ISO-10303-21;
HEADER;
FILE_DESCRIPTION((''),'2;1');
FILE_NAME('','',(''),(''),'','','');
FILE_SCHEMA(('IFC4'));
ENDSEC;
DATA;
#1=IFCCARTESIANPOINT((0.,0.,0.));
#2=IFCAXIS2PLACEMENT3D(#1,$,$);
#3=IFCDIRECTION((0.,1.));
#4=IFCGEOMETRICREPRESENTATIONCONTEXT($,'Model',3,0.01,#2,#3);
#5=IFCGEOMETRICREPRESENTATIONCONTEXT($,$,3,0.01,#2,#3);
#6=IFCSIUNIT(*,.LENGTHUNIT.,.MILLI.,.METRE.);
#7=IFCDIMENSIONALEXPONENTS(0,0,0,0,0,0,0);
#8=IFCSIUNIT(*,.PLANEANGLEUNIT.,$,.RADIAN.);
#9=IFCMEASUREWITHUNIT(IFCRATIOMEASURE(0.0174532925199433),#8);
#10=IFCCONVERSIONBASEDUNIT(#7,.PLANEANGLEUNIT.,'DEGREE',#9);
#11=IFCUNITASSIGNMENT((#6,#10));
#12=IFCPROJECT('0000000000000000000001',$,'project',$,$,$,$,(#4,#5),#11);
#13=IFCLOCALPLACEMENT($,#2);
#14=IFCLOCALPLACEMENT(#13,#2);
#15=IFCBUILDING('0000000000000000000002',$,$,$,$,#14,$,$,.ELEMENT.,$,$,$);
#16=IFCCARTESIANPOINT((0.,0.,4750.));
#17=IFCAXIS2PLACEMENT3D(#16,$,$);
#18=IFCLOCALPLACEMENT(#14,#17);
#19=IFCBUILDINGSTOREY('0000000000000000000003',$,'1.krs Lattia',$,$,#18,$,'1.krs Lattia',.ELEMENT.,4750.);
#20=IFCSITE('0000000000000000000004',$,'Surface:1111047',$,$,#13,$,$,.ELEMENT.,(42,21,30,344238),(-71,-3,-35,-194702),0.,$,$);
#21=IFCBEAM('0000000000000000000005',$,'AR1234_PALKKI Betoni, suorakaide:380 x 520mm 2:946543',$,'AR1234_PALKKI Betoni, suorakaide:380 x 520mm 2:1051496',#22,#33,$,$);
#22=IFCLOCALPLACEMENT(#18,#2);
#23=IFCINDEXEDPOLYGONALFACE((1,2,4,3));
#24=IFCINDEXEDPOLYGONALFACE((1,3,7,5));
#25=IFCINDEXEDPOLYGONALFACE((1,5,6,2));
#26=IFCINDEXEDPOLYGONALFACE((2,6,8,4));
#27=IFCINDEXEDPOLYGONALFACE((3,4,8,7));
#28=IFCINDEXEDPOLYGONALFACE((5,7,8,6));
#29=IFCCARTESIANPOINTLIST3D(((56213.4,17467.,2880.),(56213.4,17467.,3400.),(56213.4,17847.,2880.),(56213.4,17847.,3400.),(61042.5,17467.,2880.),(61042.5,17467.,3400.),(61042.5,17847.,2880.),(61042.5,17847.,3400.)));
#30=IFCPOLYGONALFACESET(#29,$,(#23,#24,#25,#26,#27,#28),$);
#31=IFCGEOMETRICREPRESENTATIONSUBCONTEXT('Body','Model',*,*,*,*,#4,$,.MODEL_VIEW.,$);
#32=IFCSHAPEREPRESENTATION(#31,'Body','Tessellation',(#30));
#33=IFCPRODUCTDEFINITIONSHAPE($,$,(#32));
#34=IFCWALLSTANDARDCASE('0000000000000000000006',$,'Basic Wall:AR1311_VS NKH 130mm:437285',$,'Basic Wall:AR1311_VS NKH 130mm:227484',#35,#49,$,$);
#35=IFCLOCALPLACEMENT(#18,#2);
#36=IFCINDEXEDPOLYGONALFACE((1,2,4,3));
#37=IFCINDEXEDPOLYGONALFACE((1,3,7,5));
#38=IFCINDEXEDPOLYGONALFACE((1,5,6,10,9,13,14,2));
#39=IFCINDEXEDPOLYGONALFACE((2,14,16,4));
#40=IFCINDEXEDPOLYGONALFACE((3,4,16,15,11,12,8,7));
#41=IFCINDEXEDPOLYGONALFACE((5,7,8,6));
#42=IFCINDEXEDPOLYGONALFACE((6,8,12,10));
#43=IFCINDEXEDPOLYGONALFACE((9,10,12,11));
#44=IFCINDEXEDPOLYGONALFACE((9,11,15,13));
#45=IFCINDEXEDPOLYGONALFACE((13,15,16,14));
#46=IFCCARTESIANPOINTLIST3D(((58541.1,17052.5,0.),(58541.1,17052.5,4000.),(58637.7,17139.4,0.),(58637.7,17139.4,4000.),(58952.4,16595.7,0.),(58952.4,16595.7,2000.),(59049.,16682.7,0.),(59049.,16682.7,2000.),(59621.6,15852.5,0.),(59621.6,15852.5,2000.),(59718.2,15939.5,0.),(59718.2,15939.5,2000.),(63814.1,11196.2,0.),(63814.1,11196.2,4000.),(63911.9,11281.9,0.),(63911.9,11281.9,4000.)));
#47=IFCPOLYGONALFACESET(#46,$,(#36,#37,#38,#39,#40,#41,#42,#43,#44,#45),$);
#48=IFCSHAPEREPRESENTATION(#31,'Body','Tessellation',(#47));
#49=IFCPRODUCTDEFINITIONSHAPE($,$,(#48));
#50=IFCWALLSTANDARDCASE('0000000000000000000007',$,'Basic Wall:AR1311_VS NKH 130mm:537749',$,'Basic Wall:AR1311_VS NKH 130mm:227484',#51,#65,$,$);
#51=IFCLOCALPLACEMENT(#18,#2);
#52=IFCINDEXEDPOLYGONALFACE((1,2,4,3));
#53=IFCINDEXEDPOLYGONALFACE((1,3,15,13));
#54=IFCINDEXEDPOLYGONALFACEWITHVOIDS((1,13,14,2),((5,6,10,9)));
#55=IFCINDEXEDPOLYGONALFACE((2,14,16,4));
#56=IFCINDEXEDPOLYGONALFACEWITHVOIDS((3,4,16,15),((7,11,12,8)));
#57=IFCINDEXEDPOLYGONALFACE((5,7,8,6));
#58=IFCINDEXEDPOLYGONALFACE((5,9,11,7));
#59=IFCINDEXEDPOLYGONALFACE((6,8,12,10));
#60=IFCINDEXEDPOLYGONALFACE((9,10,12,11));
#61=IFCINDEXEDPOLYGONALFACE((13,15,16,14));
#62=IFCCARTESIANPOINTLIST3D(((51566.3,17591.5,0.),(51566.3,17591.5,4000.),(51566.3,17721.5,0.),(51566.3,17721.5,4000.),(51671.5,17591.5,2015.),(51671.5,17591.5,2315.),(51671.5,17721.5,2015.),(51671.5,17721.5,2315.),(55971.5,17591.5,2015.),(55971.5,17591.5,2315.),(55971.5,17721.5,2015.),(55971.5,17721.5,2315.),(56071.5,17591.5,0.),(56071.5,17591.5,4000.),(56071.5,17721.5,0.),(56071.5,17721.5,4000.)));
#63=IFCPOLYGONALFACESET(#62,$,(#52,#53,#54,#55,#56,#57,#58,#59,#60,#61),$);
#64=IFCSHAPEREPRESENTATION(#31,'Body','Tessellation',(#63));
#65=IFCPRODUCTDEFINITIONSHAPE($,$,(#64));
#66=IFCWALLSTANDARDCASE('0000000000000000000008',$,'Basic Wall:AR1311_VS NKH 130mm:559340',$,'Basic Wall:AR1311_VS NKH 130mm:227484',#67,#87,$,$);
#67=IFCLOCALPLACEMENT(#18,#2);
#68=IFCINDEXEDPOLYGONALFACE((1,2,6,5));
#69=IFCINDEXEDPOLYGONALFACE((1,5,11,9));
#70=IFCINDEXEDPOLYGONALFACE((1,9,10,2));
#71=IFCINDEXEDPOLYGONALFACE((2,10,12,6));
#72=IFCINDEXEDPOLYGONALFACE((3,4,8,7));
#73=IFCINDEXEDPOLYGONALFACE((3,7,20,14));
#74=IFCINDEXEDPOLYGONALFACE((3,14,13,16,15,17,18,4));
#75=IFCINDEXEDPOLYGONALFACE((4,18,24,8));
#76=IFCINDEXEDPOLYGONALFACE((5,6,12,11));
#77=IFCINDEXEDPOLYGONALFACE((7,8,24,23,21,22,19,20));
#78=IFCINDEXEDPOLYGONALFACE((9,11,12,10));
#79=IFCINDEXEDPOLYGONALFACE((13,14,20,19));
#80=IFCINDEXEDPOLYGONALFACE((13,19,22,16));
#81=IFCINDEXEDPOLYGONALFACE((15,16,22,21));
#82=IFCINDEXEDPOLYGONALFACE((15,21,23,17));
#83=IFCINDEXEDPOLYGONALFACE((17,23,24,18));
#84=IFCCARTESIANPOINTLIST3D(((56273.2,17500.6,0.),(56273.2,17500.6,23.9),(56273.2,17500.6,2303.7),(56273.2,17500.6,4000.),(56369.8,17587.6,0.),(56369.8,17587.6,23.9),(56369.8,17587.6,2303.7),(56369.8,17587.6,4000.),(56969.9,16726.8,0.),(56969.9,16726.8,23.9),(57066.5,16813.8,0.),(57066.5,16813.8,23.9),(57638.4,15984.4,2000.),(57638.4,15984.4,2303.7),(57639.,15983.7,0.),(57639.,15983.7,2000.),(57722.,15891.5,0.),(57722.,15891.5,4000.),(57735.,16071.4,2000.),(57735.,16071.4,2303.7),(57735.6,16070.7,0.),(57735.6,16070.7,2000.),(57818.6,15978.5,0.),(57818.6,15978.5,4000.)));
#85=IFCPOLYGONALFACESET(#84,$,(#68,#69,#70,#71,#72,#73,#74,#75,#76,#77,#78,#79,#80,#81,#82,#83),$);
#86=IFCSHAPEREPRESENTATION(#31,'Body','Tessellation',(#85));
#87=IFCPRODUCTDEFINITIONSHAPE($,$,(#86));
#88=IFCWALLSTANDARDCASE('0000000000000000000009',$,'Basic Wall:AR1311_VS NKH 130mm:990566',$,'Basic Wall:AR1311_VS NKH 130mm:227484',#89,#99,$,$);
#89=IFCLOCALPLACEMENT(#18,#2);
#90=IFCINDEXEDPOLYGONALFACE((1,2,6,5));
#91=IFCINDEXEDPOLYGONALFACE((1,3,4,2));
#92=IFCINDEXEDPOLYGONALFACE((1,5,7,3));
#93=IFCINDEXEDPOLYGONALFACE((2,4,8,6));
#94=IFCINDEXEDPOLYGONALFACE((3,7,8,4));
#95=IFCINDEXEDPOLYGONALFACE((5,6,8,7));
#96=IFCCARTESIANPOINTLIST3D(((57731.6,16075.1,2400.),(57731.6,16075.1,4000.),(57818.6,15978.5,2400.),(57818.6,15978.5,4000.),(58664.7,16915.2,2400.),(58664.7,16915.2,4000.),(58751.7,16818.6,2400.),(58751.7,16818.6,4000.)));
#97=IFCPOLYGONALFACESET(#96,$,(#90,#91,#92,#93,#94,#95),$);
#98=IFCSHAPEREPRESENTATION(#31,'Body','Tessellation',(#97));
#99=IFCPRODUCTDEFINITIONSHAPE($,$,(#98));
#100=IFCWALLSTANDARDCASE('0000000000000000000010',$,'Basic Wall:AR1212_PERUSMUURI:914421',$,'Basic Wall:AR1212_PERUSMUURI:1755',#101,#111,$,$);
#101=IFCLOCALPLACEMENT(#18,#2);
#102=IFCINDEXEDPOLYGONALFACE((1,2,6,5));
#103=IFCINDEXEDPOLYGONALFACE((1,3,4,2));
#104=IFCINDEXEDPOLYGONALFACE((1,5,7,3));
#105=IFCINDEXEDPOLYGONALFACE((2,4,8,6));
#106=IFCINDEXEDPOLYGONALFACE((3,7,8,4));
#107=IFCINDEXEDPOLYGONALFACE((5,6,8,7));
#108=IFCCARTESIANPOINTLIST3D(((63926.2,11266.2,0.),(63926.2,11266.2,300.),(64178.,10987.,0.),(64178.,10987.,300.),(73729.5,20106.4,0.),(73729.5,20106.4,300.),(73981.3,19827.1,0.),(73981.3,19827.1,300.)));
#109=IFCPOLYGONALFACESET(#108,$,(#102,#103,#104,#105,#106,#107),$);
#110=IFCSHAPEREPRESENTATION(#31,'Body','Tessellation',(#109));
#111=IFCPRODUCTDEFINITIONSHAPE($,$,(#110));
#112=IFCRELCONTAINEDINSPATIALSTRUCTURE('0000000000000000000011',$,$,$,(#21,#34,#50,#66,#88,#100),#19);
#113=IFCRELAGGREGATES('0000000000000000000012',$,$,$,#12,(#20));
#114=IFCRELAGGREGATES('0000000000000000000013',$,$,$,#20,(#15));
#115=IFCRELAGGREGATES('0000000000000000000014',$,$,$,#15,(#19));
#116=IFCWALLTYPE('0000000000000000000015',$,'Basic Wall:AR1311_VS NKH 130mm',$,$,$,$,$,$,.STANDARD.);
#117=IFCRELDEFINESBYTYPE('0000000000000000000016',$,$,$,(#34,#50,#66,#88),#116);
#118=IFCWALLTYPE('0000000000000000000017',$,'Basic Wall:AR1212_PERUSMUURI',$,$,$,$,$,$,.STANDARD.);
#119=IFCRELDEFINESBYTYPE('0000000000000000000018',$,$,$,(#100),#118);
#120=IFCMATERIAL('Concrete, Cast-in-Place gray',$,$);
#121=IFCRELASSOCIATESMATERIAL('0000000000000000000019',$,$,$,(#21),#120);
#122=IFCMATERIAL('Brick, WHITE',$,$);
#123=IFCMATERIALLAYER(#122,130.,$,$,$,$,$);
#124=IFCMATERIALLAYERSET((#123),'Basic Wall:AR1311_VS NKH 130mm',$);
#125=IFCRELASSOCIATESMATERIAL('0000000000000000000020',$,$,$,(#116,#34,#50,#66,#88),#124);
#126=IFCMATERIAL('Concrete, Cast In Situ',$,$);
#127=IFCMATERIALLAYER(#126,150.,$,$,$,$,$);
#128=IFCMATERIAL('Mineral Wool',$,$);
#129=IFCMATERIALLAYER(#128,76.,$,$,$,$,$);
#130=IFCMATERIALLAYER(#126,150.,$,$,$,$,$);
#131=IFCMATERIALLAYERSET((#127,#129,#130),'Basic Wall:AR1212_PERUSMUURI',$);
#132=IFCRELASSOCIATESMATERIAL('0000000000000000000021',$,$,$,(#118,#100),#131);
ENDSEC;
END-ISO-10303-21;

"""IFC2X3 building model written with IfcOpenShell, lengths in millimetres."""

from ifc_helpers import new_model, entity, si_unit, converted_unit, direction, frame, frame_2d, origin, place, context, subcontext, project, spatial, polyline, rectangle, outline, extrude, material, layer, layer_set, layer_usage, type_object, element, save


model = new_model("IFC2X3")

# Units and contexts
model_context = context("Model", 3, precision=0.01, world=origin(), true_north=direction((0.0, 1.0)))
context_of_model = context(None, 3, precision=0.01, world=origin(), true_north=direction((0.0, 1.0)))
body_context = subcontext(model_context, "Body", "Model", "MODEL_VIEW")
ifc_project = project(units=[si_unit("LENGTHUNIT", "METRE", prefix="MILLI"), converted_unit("PLANEANGLEUNIT", "DEGREE", entity("IfcRatioMeasure", 0.0174532925199433), si_unit("PLANEANGLEUNIT", "RADIAN"), dimensions=[0, 0, 0, 0, 0, 0, 0])], contexts=[model_context, context_of_model])

# Site, building, storey
site_placement = place(None, origin())
site = spatial("IfcSite", under=ifc_project, at=site_placement, Name="Surface:1111047", CompositionType="ELEMENT", RefLatitude=(42, 21, 30, 344238), RefLongitude=(-71, -3, -35, -194702), RefElevation=0.0)
building_placement = place(site_placement, origin())
building = spatial("IfcBuilding", under=site, at=building_placement, CompositionType="ELEMENT")
storey_placement = place(building_placement, frame((0.0, 0.0, 4750.0)))
storey = spatial("IfcBuildingStorey", under=building, at=storey_placement, Name="1.krs Lattia", LongName="1.krs Lattia", CompositionType="ELEMENT", Elevation=4750.0)

# Beam
ifc_material_1 = material(Name="Concrete, Cast-in-Place gray")
beam_1_placement = place(storey_placement, frame((61042.5, 17657.0, 0.0), z_axis=(0.0, 0.0, 1.0), x_axis=(-1.0, 0.0, 0.0)))
element("IfcBeam", 1, at=beam_1_placement, inside=storey, material=ifc_material_1, Name="AR1234_PALKKI Betoni, suorakaide:380 x 520mm 2:946543", ObjectType="AR1234_PALKKI Betoni, suorakaide:380 x 520mm 2:1051496", context=body_context, shape_type="SweptSolid", body=[
    extrude(rectangle(XDim=520.0, YDim=380.0, at=frame_2d((0.0, 0.0), x_axis=(1.0, 0.0))), frame((0.0, 0.0, 3140.0), z_axis=(1.0, 0.0, 0.0), x_axis=(0.0, 0.0, -1.0)), (0.0, 0.0, 1.0), 4829.1),
])

# Walls, openings
ifc_material_2 = material(Name="Brick, WHITE")
ifc_layer_1 = layer(ifc_material_2, 130.0)
ifc_layer_set_1 = layer_set([ifc_layer_1], Name="Basic Wall:AR1311_VS NKH 130mm")
ifc_layer_usage_1 = layer_usage(ifc_layer_set_1, "AXIS2", "NEGATIVE", 65.0)
wall_type_1 = type_object("IfcWallType", Name="Basic Wall:AR1311_VS NKH 130mm", PredefinedType="STANDARD", material=ifc_layer_set_1)
wall_1_placement = place(storey_placement, frame((58589.4, 17096.0, 0.0), z_axis=(0.0, 0.0, 1.0), x_axis=(0.669131, -0.743145, 0.0)))
wall_1 = element("IfcWallStandardCase", 2, at=wall_1_placement, inside=storey, type_object=wall_type_1, material=ifc_layer_usage_1, Name="Basic Wall:AR1311_VS NKH 130mm:437285", ObjectType="Basic Wall:AR1311_VS NKH 130mm:227484", context=body_context, shape_type="SweptSolid", body=[
    extrude(outline(polyline([(0.0, -65.0), (7880.4, -65.0), (7882.2, 65.0), (0.0, 65.0), (0.0, -65.0)])), origin(), (0.0, 0.0, 1.0), 4000.0),
])
opening_1_placement = place(wall_1_placement, frame((614.7, -65.0, 0.0)))
element("IfcOpeningElement", 3, at=opening_1_placement, cuts=wall_1, ObjectType="Opening", context=body_context, shape_type="SweptSolid", body=[
    extrude(rectangle(XDim=2000.0, YDim=1000.0, at=frame_2d((1000.0, 500.0), x_axis=(1.0, 0.0))), frame((0.0, 0.0, 0.0), z_axis=(0.0, 1.0, 0.0), x_axis=(0.0, 0.0, 1.0)), (0.0, 0.0, 1.0), 130.0),
])
ifc_layer_usage_2 = layer_usage(ifc_layer_set_1, "AXIS2", "NEGATIVE", 65.0)
wall_2_placement = place(storey_placement, frame((51566.3, 17656.5, 0.0)))
wall_2 = element("IfcWallStandardCase", 4, at=wall_2_placement, inside=storey, type_object=wall_type_1, material=ifc_layer_usage_2, Name="Basic Wall:AR1311_VS NKH 130mm:537749", ObjectType="Basic Wall:AR1311_VS NKH 130mm:227484", context=body_context, shape_type="SweptSolid", body=[
    extrude(rectangle(XDim=4505.2, YDim=130.0, at=frame_2d((2252.6, 0.0), x_axis=(-1.0, 0.0))), origin(), (0.0, 0.0, 1.0), 4000.0),
])
opening_2_placement = place(wall_2_placement, origin())
element("IfcOpeningElement", 5, at=opening_2_placement, cuts=wall_2, ObjectType="Opening", context=body_context, shape_type="SweptSolid", body=[
    extrude(rectangle(XDim=300.0, YDim=4300.0, at=frame_2d((0.0, 0.0), x_axis=(1.0, 0.0))), frame((2255.2, -65.0, 2165.0), z_axis=(0.0, 1.0, 0.0), x_axis=(0.0, 0.0, -1.0)), (0.0, 0.0, 1.0), 130.0),
])

# Wall, openings
ifc_layer_usage_3 = layer_usage(ifc_layer_set_1, "AXIS2", "NEGATIVE", 65.0)
wall_3_placement = place(storey_placement, frame((57770.3, 15935.0, 0.0), z_axis=(0.0, 0.0, 1.0), x_axis=(-0.669131, 0.743145, 0.0)))
wall_3 = element("IfcWallStandardCase", 6, at=wall_3_placement, inside=storey, type_object=wall_type_1, material=ifc_layer_usage_3, Name="Basic Wall:AR1311_VS NKH 130mm:559340", ObjectType="Basic Wall:AR1311_VS NKH 130mm:227484", context=body_context, shape_type="SweptSolid", body=[
    extrude(rectangle(XDim=2165.3, YDim=130.0, at=frame_2d((1082.6, 0.0), x_axis=(-1.0, 0.0))), origin(), (0.0, 0.0, 1.0), 4000.0),
])
opening_3_placement = place(wall_3_placement, origin())
element("IfcOpeningElement", 7, at=opening_3_placement, cuts=wall_3, ObjectType="Opening", context=body_context, shape_type="SweptSolid", body=[
    extrude(rectangle(XDim=2279.8, YDim=2040.3, at=frame_2d((0.0, 0.0), x_axis=(1.0, 0.0))), frame((1145.1, -65.0, 1163.8), z_axis=(0.0, 1.0, 0.0), x_axis=(0.0, 0.0, -1.0)), (0.0, 0.0, 1.0), 130.0),
])
opening_4_placement = place(wall_3_placement, frame((1124.1, 65.0, 0.0)))
element("IfcOpeningElement", 8, at=opening_4_placement, cuts=wall_3, ObjectType="Opening", context=body_context, shape_type="SweptSolid", body=[
    extrude(rectangle(XDim=2000.0, YDim=1000.0, at=frame_2d((1000.0, 500.0), x_axis=(1.0, 0.0))), frame((0.0, 0.0, 0.0), z_axis=(0.0, -1.0, 0.0), x_axis=(0.0, 0.0, 1.0)), (0.0, 0.0, 1.0), 130.0),
])

# Walls
ifc_layer_usage_4 = layer_usage(ifc_layer_set_1, "AXIS2", "NEGATIVE", 65.0)
wall_4_placement = place(storey_placement, frame((58708.2, 16866.9, 2400.0), z_axis=(0.0, 0.0, 1.0), x_axis=(-0.743145, -0.669131, 0.0)))
element("IfcWallStandardCase", 9, at=wall_4_placement, inside=storey, type_object=wall_type_1, material=ifc_layer_usage_4, Name="Basic Wall:AR1311_VS NKH 130mm:990566", ObjectType="Basic Wall:AR1311_VS NKH 130mm:227484", context=body_context, shape_type="SweptSolid", body=[
    extrude(rectangle(XDim=1255.6, YDim=130.0, at=frame_2d((627.8, 0.0), x_axis=(-1.0, 0.0))), origin(), (0.0, 0.0, 1.0), 1600.0),
])
ifc_material_3 = material(Name="Concrete, Cast In Situ")
ifc_layer_2 = layer(ifc_material_3, 150.0)
ifc_material_4 = material(Name="Mineral Wool")
ifc_layer_3 = layer(ifc_material_4, 76.0)
ifc_layer_4 = layer(ifc_material_3, 150.0)
ifc_layer_set_2 = layer_set([ifc_layer_2, ifc_layer_3, ifc_layer_4], Name="Basic Wall:AR1212_PERUSMUURI")
ifc_layer_usage_5 = layer_usage(ifc_layer_set_2, "AXIS2", "NEGATIVE", 188.0)
wall_type_2 = type_object("IfcWallType", Name="Basic Wall:AR1212_PERUSMUURI", PredefinedType="STANDARD", material=ifc_layer_set_2)
wall_5_placement = place(storey_placement, frame((64052.1, 11126.6, 0.0), z_axis=(0.0, 0.0, 1.0), x_axis=(0.742646, 0.669684, 0.0)))
element("IfcWallStandardCase", 10, at=wall_5_placement, inside=storey, type_object=wall_type_2, material=ifc_layer_usage_5, Name="Basic Wall:AR1212_PERUSMUURI:914421", ObjectType="Basic Wall:AR1212_PERUSMUURI:1755", context=body_context, shape_type="SweptSolid", body=[
    extrude(rectangle(XDim=13200.5, YDim=376.0, at=frame_2d((6600.2, 0.0), x_axis=(-1.0, 0.0))), origin(), (0.0, 0.0, 1.0), 300.0),
])

save(model, "model.ifc")
